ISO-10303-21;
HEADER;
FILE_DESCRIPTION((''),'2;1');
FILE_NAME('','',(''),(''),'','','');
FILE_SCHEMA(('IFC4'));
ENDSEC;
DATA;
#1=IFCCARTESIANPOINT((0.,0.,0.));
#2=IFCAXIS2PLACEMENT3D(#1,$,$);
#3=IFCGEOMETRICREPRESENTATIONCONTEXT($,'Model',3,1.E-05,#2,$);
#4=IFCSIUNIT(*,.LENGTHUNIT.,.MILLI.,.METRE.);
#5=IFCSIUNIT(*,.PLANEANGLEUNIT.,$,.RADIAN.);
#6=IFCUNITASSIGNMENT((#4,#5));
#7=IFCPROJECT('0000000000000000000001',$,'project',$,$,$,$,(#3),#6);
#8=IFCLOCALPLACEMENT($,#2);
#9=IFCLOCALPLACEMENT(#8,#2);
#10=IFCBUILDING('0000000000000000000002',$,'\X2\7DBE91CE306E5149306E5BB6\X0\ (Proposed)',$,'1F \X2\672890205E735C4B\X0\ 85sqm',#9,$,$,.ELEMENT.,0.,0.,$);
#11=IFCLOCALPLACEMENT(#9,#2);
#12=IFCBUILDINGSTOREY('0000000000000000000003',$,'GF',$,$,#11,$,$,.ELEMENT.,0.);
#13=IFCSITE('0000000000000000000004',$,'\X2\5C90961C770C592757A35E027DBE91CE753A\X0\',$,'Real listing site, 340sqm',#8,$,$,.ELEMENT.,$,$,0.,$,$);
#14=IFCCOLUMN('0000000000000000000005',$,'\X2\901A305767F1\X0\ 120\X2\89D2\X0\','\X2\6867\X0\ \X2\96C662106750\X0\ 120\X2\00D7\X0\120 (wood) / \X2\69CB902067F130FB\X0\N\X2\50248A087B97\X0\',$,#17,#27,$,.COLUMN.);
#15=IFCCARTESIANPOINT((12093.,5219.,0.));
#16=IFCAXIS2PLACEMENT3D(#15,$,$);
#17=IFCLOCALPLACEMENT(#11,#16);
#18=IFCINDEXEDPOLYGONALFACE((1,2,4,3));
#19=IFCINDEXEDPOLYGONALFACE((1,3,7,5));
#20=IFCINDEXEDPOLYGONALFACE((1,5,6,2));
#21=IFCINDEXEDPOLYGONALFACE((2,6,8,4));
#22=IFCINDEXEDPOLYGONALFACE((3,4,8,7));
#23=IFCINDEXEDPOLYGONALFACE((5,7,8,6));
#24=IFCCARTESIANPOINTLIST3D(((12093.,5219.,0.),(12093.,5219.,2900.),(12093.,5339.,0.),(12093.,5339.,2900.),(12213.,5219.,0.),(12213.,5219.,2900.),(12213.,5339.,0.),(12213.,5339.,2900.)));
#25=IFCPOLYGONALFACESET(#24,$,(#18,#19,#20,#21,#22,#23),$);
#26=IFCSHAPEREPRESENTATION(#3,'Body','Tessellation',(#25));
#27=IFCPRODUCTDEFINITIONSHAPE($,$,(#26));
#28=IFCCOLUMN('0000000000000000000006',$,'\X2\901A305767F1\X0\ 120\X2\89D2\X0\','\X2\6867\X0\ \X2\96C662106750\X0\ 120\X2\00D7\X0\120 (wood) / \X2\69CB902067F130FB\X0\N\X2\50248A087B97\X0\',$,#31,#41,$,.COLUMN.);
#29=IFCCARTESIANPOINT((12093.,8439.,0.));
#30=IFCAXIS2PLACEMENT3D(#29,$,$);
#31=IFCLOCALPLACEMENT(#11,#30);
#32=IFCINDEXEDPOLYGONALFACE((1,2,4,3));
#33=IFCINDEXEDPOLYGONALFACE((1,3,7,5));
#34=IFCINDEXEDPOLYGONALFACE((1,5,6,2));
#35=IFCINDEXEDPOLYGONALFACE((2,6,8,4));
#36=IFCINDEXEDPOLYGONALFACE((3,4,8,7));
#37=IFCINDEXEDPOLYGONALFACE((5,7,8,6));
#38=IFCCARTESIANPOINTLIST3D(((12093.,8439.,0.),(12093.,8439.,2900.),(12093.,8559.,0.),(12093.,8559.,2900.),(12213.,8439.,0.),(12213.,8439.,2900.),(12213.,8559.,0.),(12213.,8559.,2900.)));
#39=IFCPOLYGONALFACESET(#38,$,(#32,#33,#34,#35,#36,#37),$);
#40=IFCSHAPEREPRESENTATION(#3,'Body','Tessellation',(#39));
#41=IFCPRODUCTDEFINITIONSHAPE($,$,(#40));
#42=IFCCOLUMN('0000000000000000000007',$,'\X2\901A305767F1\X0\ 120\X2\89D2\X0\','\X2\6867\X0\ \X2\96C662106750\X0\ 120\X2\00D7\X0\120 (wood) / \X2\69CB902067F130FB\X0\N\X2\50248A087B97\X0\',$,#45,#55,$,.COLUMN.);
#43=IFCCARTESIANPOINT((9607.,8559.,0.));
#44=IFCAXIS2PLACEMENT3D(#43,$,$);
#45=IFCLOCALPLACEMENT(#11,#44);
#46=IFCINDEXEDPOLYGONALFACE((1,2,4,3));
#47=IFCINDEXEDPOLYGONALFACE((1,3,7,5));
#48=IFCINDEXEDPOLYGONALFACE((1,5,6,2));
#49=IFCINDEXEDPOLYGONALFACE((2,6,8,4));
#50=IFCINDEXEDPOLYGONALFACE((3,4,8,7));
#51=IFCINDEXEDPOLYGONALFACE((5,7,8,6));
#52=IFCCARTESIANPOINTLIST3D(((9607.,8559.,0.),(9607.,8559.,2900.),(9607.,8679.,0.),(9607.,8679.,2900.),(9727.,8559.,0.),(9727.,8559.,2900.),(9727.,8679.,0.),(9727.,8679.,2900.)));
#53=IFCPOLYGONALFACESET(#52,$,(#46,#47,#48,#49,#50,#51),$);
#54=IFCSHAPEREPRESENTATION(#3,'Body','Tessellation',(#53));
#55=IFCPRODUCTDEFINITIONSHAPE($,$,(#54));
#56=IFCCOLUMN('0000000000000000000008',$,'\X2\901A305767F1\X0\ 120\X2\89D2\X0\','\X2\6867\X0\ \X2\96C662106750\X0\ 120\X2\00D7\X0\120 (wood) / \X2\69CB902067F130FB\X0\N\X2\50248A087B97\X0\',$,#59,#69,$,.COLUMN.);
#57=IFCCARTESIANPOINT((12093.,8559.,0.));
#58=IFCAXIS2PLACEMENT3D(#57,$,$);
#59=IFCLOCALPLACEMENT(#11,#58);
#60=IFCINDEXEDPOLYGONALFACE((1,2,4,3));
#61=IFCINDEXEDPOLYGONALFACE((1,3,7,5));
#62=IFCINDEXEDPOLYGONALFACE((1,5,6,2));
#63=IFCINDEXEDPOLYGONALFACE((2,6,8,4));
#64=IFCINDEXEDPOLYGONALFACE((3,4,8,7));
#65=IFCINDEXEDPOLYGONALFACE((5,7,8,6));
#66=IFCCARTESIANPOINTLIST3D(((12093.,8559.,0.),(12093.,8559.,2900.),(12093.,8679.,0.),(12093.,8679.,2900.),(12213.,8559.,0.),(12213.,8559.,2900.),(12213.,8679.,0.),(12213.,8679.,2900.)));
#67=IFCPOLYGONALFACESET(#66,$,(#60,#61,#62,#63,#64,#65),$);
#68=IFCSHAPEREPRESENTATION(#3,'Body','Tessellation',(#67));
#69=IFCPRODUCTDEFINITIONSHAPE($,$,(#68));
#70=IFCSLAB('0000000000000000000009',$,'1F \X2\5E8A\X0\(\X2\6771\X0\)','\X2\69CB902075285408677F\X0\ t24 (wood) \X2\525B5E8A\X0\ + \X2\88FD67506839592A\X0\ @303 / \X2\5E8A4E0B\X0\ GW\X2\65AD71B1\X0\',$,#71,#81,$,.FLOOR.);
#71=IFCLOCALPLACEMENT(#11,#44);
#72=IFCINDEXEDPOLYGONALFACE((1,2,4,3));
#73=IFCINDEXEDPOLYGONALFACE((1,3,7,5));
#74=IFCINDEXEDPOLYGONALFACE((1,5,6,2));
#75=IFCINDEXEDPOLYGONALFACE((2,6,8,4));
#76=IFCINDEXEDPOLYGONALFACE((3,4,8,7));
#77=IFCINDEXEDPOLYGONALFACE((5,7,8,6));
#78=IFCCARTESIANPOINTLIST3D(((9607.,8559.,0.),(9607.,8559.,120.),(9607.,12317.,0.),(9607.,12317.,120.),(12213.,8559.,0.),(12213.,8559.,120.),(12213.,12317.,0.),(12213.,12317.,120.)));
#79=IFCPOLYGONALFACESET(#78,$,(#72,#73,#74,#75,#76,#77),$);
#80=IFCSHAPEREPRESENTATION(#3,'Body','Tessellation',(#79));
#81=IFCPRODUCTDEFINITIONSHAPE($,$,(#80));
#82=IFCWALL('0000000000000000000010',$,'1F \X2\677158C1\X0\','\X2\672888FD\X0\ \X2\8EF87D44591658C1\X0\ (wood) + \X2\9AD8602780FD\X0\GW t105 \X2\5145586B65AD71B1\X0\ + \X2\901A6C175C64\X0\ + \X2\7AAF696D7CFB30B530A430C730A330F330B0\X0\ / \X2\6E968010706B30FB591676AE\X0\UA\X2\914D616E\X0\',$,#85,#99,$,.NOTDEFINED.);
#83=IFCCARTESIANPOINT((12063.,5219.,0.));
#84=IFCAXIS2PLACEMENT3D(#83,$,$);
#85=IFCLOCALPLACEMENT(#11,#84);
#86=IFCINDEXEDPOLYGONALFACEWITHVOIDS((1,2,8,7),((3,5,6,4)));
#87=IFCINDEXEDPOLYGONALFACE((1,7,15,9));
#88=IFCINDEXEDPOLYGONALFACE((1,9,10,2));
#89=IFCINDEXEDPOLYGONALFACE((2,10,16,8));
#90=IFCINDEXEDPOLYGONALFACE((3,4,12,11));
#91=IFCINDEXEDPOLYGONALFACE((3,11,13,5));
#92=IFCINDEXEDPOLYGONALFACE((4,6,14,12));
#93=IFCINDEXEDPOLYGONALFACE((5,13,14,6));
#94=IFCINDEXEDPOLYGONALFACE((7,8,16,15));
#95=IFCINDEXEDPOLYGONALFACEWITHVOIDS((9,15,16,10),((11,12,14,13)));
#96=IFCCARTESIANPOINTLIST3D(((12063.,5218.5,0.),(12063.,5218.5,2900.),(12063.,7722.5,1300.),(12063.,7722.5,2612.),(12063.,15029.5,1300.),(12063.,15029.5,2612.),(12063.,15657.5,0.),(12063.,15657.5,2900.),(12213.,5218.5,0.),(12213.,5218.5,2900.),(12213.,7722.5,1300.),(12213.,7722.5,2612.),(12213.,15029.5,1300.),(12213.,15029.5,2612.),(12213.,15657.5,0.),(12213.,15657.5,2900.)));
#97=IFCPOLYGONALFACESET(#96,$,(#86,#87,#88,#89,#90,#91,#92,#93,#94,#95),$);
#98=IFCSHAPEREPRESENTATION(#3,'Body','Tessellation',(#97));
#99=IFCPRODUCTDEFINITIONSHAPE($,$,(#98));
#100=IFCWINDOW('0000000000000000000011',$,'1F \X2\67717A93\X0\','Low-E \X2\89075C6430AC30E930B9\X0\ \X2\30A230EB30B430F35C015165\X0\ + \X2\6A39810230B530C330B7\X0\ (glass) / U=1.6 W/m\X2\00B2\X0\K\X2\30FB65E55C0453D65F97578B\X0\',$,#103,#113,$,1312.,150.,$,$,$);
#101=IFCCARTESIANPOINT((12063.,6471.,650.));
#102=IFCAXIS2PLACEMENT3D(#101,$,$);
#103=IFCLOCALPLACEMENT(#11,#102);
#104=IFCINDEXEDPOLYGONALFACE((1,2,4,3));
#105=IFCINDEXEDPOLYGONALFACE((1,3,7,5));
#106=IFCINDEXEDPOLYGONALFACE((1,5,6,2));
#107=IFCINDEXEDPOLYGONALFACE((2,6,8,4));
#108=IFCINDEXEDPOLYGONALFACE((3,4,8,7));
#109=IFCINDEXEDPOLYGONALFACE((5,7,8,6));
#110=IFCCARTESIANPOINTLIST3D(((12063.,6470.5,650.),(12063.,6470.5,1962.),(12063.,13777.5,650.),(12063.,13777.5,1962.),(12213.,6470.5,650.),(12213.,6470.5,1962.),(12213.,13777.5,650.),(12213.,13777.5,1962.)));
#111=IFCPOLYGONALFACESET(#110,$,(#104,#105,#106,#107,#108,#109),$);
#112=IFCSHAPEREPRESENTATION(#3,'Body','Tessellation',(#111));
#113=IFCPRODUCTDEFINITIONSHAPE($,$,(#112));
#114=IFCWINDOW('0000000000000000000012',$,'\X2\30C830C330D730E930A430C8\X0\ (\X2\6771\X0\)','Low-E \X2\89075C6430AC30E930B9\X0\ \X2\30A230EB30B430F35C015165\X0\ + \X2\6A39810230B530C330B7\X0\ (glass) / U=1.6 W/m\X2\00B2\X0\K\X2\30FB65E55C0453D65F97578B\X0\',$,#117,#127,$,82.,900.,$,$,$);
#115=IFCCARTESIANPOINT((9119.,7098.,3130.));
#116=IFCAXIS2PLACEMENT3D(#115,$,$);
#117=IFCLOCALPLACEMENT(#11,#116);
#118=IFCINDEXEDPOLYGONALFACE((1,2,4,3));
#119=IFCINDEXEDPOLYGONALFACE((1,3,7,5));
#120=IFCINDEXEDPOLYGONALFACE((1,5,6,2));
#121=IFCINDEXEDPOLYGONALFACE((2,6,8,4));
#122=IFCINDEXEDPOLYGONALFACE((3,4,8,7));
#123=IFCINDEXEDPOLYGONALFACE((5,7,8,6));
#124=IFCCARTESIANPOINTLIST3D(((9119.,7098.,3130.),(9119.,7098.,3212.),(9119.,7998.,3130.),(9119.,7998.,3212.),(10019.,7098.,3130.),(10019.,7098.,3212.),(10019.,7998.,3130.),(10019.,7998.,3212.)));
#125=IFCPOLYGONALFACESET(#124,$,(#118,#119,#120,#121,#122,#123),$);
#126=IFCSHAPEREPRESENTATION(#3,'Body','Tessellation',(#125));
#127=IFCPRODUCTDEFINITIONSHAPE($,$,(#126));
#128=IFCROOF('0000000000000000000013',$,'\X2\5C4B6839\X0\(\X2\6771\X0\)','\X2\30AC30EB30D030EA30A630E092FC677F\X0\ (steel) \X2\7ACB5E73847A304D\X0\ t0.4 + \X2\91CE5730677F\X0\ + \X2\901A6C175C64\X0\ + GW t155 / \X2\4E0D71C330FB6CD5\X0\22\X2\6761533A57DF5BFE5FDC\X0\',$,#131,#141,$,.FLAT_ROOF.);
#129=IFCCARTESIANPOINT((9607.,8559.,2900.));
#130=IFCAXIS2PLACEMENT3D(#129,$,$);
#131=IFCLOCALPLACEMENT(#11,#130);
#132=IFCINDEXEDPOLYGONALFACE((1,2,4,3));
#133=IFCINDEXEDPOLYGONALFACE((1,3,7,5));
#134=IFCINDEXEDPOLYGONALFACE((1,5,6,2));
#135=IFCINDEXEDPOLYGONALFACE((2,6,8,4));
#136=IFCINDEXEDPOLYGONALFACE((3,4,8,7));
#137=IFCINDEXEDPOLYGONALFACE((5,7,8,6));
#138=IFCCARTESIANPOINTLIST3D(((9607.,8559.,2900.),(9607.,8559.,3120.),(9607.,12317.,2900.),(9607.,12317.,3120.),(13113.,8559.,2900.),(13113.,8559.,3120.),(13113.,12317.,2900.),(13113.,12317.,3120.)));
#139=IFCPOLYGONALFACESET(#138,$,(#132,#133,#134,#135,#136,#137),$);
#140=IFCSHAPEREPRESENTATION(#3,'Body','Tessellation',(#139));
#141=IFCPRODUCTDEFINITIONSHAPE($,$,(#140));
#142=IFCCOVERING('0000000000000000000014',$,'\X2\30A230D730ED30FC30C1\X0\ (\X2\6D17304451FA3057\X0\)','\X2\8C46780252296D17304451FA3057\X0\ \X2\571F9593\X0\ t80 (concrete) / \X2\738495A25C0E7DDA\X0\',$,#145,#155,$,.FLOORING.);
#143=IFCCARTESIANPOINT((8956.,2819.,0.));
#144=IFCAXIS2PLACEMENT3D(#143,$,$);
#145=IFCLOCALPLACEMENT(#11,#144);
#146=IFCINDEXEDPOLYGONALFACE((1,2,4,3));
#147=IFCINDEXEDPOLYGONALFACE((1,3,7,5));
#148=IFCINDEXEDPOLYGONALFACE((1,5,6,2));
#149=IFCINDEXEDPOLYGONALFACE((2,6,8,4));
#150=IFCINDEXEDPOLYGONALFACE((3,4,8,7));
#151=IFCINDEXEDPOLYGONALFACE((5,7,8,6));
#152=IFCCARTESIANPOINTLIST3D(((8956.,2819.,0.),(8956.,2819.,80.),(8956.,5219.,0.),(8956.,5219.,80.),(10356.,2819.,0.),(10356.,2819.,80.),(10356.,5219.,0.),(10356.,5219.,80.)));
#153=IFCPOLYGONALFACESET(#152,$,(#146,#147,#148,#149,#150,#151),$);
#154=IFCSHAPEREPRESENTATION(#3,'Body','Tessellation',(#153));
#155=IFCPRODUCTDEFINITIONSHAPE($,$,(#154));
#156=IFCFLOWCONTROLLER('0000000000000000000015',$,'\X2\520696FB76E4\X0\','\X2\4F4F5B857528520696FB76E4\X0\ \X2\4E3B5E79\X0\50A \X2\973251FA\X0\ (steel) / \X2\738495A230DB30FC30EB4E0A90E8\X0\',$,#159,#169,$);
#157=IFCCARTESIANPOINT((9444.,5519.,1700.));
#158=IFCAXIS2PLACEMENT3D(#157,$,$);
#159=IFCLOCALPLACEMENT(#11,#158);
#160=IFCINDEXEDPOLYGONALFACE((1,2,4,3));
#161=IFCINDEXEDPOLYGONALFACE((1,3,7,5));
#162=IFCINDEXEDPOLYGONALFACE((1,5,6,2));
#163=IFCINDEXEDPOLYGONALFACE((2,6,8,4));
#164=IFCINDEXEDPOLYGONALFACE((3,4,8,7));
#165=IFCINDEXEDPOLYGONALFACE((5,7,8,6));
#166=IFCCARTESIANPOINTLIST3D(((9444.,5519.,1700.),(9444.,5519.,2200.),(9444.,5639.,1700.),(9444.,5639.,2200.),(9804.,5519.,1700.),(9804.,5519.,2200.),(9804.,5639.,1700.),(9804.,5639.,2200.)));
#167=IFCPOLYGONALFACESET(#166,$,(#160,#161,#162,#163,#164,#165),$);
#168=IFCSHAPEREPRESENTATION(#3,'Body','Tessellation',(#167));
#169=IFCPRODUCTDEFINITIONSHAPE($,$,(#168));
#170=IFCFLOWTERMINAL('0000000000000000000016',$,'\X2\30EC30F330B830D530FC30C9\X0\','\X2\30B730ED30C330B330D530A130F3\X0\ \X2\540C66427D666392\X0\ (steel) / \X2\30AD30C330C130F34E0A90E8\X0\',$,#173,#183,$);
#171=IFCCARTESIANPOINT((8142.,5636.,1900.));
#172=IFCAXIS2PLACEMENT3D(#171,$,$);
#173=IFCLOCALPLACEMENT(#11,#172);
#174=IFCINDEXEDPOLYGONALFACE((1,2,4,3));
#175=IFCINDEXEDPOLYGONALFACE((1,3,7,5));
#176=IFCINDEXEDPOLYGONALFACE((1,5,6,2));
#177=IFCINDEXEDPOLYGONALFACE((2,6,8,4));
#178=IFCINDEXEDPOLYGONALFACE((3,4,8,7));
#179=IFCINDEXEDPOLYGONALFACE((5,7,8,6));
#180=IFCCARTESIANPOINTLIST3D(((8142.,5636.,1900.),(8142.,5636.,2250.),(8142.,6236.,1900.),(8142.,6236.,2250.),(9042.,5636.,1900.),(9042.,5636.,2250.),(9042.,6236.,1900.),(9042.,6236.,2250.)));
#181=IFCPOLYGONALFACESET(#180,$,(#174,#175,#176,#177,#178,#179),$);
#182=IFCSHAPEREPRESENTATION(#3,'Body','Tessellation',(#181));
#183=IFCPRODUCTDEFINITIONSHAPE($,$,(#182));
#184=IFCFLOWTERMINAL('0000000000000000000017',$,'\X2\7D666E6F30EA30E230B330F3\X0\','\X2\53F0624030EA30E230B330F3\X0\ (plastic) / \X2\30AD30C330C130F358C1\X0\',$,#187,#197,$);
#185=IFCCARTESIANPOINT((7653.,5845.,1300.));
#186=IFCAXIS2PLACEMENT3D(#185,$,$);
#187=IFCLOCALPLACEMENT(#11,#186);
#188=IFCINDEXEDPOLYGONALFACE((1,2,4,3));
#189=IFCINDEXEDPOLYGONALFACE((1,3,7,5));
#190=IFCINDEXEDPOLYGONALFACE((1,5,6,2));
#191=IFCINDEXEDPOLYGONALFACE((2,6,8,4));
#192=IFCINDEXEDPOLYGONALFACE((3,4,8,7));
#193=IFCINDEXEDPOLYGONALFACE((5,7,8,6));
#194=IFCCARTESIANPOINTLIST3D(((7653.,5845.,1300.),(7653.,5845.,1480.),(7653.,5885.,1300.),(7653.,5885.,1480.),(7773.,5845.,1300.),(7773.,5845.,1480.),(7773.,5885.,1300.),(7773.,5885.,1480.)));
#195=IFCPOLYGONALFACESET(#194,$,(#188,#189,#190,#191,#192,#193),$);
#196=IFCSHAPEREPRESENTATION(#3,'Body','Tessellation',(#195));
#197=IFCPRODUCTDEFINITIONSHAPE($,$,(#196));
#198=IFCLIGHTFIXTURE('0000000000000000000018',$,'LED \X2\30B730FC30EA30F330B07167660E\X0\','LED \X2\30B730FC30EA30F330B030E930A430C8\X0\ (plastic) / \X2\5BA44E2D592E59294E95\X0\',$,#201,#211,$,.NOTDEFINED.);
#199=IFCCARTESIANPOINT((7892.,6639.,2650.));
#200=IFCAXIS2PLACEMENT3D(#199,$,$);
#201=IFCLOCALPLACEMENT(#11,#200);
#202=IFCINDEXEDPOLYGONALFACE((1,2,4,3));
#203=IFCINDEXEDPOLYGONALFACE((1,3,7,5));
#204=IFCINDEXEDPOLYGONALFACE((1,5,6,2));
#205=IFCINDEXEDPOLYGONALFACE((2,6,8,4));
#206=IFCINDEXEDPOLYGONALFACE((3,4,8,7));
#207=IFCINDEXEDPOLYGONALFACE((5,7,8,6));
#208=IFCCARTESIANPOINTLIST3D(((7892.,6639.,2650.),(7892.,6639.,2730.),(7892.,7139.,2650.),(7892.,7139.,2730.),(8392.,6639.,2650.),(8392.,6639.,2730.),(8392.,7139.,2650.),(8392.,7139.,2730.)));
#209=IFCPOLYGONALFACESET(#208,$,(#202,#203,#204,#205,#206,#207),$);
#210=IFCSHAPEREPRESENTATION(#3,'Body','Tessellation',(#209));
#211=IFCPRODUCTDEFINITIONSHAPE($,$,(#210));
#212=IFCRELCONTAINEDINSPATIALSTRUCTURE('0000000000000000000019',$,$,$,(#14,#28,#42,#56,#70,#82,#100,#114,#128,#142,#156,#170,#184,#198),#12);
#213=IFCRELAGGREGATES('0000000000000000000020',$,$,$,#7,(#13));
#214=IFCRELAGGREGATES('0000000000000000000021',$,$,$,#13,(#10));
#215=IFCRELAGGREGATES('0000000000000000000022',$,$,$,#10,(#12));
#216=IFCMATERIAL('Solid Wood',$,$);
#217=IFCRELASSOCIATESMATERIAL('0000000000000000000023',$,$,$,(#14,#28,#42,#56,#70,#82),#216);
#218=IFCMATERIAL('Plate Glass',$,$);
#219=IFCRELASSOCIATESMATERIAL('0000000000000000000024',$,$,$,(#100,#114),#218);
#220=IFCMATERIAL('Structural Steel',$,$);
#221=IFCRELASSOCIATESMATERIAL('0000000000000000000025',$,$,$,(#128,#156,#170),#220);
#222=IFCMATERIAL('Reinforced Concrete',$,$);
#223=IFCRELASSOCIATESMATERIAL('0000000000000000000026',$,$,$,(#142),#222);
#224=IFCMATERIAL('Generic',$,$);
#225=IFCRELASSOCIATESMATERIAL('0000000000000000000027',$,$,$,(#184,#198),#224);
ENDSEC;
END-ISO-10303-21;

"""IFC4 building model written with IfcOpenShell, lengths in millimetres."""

from ifc_helpers import new_model, si_unit, frame, frame_2d, origin, place, context, project, spatial, rectangle, extrude, material, element, fill, save


model = new_model("IFC4")

# Units and contexts
model_context = context("Model", 3, precision=1e-05, world=origin())
ifc_project = project(units=[si_unit("LENGTHUNIT", "METRE", prefix="MILLI"), si_unit("PLANEANGLEUNIT", "RADIAN")], contexts=[model_context])

# Site, building, storey
site_placement = place(None, origin())
site = spatial("IfcSite", under=ifc_project, at=site_placement, Name="岐阜県大垣市綾野町", ObjectType="Real listing site, 340sqm", CompositionType="ELEMENT", RefElevation=0.0)
building_placement = place(site_placement, origin())
building = spatial("IfcBuilding", under=site, at=building_placement, Name="綾野の光の家 (Proposed)", ObjectType="1F 木造平屋 85sqm", CompositionType="ELEMENT", ElevationOfRefHeight=0.0, ElevationOfTerrain=0.0)
storey_placement = place(building_placement, origin())
storey = spatial("IfcBuildingStorey", under=building, at=storey_placement, Name="GF", CompositionType="ELEMENT", Elevation=0.0)

# Columns
ifc_material_1 = material(Name="Solid Wood")
column_1_placement = place(storey_placement, frame((12093.0, 5219.0, 0.0)))
element("IfcColumn", 1, at=column_1_placement, inside=storey, material=ifc_material_1, Name="通し柱 120角", Description="桧 集成材 120×120 (wood) / 構造柱・N値計算", PredefinedType="COLUMN", context=model_context, shape_type="SweptSolid", body=[
    extrude(rectangle(XDim=120.0, YDim=120.0, at=frame_2d((60.0, 60.0))), frame((12093.0, 5219.0, 0.0)), (0.0, 0.0, 1.0), 2900.0),
])
column_2_placement = place(storey_placement, frame((12093.0, 8439.0, 0.0)))
element("IfcColumn", 2, at=column_2_placement, inside=storey, material=ifc_material_1, Name="通し柱 120角", Description="桧 集成材 120×120 (wood) / 構造柱・N値計算", PredefinedType="COLUMN", context=model_context, shape_type="SweptSolid", body=[
    extrude(rectangle(XDim=120.0, YDim=120.0, at=frame_2d((60.0, 60.0))), frame((12093.0, 8439.0, 0.0)), (0.0, 0.0, 1.0), 2900.0),
])
column_3_placement = place(storey_placement, frame((9607.0, 8559.0, 0.0)))
element("IfcColumn", 3, at=column_3_placement, inside=storey, material=ifc_material_1, Name="通し柱 120角", Description="桧 集成材 120×120 (wood) / 構造柱・N値計算", PredefinedType="COLUMN", context=model_context, shape_type="SweptSolid", body=[
    extrude(rectangle(XDim=120.0, YDim=120.0, at=frame_2d((60.0, 60.0))), frame((9607.0, 8559.0, 0.0)), (0.0, 0.0, 1.0), 2900.0),
])
column_4_placement = place(storey_placement, frame((12093.0, 8559.0, 0.0)))
element("IfcColumn", 4, at=column_4_placement, inside=storey, material=ifc_material_1, Name="通し柱 120角", Description="桧 集成材 120×120 (wood) / 構造柱・N値計算", PredefinedType="COLUMN", context=model_context, shape_type="SweptSolid", body=[
    extrude(rectangle(XDim=120.0, YDim=120.0, at=frame_2d((60.0, 60.0))), frame((12093.0, 8559.0, 0.0)), (0.0, 0.0, 1.0), 2900.0),
])

# Slab
slab_placement = place(storey_placement, frame((9607.0, 8559.0, 0.0)))
element("IfcSlab", 5, at=slab_placement, inside=storey, material=ifc_material_1, Name="1F 床(東)", Description="構造用合板 t24 (wood) 剛床 + 製材根太 @303 / 床下 GW断熱", PredefinedType="FLOOR", context=model_context, shape_type="SweptSolid", body=[
    extrude(rectangle(XDim=2606.0, YDim=3758.0, at=frame_2d((1303.0, 1879.0))), frame((9607.0, 8559.0, 0.0)), (0.0, 0.0, 1.0), 120.0),
])

# Wall, opening, window
wall_1_placement = place(storey_placement, frame((12063.0, 5219.0, 0.0)))
wall_1 = element("IfcWall", 6, at=wall_1_placement, inside=storey, material=ifc_material_1, Name="1F 東壁", Description="木製 軸組外壁 (wood) + 高性能GW t105 充填断熱 + 通気層 + 窯業系サイディング / 準耐火・外皮UA配慮", PredefinedType="NOTDEFINED", context=model_context, shape_type="SweptSolid", body=[
    extrude(rectangle(XDim=150.0, YDim=10439.0, at=frame_2d((75.0, 5219.0))), frame((12063.0, 5219.0, 0.0)), (0.0, 0.0, 1.0), 2900.0),
])
opening_placement = place(storey_placement, frame((12063.0, 6471.0, 650.0)))
opening = element("IfcOpeningElement", 7, at=opening_placement, cuts=wall_1, PredefinedType="NOTDEFINED", context=model_context, shape_type="SweptSolid", body=[
    extrude(rectangle(XDim=150.0, YDim=7307.0, at=frame_2d((75.0, 3653.0))), frame((12063.0, 6471.0, 650.0)), (0.0, 0.0, 1.0), 1312.0),
])
ifc_material_2 = material(Name="Plate Glass")
window_1_placement = place(storey_placement, frame((12063.0, 6471.0, 650.0)))
window_1 = element("IfcWindow", 8, at=window_1_placement, inside=storey, material=ifc_material_2, Name="1F 東窓", Description="Low-E 複層ガラス アルゴン封入 + 樹脂サッシ (glass) / U=1.6 W/m²K・日射取得型", OverallHeight=1312.0, OverallWidth=150.0, context=model_context, shape_type="SweptSolid", body=[
    extrude(rectangle(XDim=150.0, YDim=7307.0, at=frame_2d((75.0, 3653.0))), frame((12063.0, 6471.0, 650.0)), (0.0, 0.0, 1.0), 1312.0),
])
fill(opening, window_1)

# Window
window_2_placement = place(storey_placement, frame((9119.0, 7098.0, 3130.0)))
element("IfcWindow", 9, at=window_2_placement, inside=storey, material=ifc_material_2, Name="トップライト (東)", Description="Low-E 複層ガラス アルゴン封入 + 樹脂サッシ (glass) / U=1.6 W/m²K・日射取得型", OverallHeight=82.0, OverallWidth=900.0, context=model_context, shape_type="SweptSolid", body=[
    extrude(rectangle(XDim=900.0, YDim=900.0, at=frame_2d((450.0, 450.0))), frame((9119.0, 7098.0, 3130.0)), (0.0, 0.0, 1.0), 82.0),
])

# Roof
ifc_material_3 = material(Name="Structural Steel")
roof_placement = place(storey_placement, frame((9607.0, 8559.0, 2900.0)))
element("IfcRoof", 10, at=roof_placement, inside=storey, material=ifc_material_3, Name="屋根(東)", Description="ガルバリウム鋼板 (steel) 立平葺き t0.4 + 野地板 + 通気層 + GW t155 / 不燃・法22条区域対応", PredefinedType="FLAT_ROOF", context=model_context, shape_type="SweptSolid", body=[
    extrude(rectangle(XDim=3506.0, YDim=3758.0, at=frame_2d((1753.0, 1879.0))), frame((9607.0, 8559.0, 2900.0)), (0.0, 0.0, 1.0), 220.0),
])

# Covering
ifc_material_4 = material(Name="Reinforced Concrete")
covering_placement = place(storey_placement, frame((8956.0, 2819.0, 0.0)))
element("IfcCovering", 11, at=covering_placement, inside=storey, material=ifc_material_4, Name="アプローチ (洗い出し)", Description="豆砂利洗い出し 土間 t80 (concrete) / 玄関導線", PredefinedType="FLOORING", context=model_context, shape_type="SweptSolid", body=[
    extrude(rectangle(XDim=1400.0, YDim=2400.0, at=frame_2d((700.0, 1200.0))), frame((8956.0, 2819.0, 0.0)), (0.0, 0.0, 1.0), 80.0),
])

# Flow controller
flow_controller_placement = place(storey_placement, frame((9444.0, 5519.0, 1700.0)))
element("IfcFlowController", 12, at=flow_controller_placement, inside=storey, material=ifc_material_3, Name="分電盤", Description="住宅用分電盤 主幹50A 露出 (steel) / 玄関ホール上部", context=model_context, shape_type="SweptSolid", body=[
    extrude(rectangle(XDim=360.0, YDim=120.0, at=frame_2d((180.0, 60.0))), frame((9444.0, 5519.0, 1700.0)), (0.0, 0.0, 1.0), 500.0),
])

# Flow terminals
flow_terminal_1_placement = place(storey_placement, frame((8142.0, 5636.0, 1900.0)))
element("IfcFlowTerminal", 13, at=flow_terminal_1_placement, inside=storey, material=ifc_material_3, Name="レンジフード", Description="シロッコファン 同時給排 (steel) / キッチン上部", context=model_context, shape_type="SweptSolid", body=[
    extrude(rectangle(XDim=900.0, YDim=600.0, at=frame_2d((450.0, 300.0))), frame((8142.0, 5636.0, 1900.0)), (0.0, 0.0, 1.0), 350.0),
])
ifc_material_5 = material(Name="Generic")
flow_terminal_2_placement = place(storey_placement, frame((7653.0, 5845.0, 1300.0)))
element("IfcFlowTerminal", 14, at=flow_terminal_2_placement, inside=storey, material=ifc_material_5, Name="給湯リモコン", Description="台所リモコン (plastic) / キッチン壁", context=model_context, shape_type="SweptSolid", body=[
    extrude(rectangle(XDim=120.0, YDim=40.0, at=frame_2d((60.0, 20.0))), frame((7653.0, 5845.0, 1300.0)), (0.0, 0.0, 1.0), 180.0),
])

# Light fixture
light_fixture_placement = place(storey_placement, frame((7892.0, 6639.0, 2650.0)))
element("IfcLightFixture", 15, at=light_fixture_placement, inside=storey, material=ifc_material_5, Name="LED シーリング照明", Description="LED シーリングライト (plastic) / 室中央天井", PredefinedType="NOTDEFINED", context=model_context, shape_type="SweptSolid", body=[
    extrude(rectangle(XDim=500.0, YDim=500.0, at=frame_2d((250.0, 250.0))), frame((7892.0, 6639.0, 2650.0)), (0.0, 0.0, 1.0), 80.0),
])

save(model, "model.ifc")
